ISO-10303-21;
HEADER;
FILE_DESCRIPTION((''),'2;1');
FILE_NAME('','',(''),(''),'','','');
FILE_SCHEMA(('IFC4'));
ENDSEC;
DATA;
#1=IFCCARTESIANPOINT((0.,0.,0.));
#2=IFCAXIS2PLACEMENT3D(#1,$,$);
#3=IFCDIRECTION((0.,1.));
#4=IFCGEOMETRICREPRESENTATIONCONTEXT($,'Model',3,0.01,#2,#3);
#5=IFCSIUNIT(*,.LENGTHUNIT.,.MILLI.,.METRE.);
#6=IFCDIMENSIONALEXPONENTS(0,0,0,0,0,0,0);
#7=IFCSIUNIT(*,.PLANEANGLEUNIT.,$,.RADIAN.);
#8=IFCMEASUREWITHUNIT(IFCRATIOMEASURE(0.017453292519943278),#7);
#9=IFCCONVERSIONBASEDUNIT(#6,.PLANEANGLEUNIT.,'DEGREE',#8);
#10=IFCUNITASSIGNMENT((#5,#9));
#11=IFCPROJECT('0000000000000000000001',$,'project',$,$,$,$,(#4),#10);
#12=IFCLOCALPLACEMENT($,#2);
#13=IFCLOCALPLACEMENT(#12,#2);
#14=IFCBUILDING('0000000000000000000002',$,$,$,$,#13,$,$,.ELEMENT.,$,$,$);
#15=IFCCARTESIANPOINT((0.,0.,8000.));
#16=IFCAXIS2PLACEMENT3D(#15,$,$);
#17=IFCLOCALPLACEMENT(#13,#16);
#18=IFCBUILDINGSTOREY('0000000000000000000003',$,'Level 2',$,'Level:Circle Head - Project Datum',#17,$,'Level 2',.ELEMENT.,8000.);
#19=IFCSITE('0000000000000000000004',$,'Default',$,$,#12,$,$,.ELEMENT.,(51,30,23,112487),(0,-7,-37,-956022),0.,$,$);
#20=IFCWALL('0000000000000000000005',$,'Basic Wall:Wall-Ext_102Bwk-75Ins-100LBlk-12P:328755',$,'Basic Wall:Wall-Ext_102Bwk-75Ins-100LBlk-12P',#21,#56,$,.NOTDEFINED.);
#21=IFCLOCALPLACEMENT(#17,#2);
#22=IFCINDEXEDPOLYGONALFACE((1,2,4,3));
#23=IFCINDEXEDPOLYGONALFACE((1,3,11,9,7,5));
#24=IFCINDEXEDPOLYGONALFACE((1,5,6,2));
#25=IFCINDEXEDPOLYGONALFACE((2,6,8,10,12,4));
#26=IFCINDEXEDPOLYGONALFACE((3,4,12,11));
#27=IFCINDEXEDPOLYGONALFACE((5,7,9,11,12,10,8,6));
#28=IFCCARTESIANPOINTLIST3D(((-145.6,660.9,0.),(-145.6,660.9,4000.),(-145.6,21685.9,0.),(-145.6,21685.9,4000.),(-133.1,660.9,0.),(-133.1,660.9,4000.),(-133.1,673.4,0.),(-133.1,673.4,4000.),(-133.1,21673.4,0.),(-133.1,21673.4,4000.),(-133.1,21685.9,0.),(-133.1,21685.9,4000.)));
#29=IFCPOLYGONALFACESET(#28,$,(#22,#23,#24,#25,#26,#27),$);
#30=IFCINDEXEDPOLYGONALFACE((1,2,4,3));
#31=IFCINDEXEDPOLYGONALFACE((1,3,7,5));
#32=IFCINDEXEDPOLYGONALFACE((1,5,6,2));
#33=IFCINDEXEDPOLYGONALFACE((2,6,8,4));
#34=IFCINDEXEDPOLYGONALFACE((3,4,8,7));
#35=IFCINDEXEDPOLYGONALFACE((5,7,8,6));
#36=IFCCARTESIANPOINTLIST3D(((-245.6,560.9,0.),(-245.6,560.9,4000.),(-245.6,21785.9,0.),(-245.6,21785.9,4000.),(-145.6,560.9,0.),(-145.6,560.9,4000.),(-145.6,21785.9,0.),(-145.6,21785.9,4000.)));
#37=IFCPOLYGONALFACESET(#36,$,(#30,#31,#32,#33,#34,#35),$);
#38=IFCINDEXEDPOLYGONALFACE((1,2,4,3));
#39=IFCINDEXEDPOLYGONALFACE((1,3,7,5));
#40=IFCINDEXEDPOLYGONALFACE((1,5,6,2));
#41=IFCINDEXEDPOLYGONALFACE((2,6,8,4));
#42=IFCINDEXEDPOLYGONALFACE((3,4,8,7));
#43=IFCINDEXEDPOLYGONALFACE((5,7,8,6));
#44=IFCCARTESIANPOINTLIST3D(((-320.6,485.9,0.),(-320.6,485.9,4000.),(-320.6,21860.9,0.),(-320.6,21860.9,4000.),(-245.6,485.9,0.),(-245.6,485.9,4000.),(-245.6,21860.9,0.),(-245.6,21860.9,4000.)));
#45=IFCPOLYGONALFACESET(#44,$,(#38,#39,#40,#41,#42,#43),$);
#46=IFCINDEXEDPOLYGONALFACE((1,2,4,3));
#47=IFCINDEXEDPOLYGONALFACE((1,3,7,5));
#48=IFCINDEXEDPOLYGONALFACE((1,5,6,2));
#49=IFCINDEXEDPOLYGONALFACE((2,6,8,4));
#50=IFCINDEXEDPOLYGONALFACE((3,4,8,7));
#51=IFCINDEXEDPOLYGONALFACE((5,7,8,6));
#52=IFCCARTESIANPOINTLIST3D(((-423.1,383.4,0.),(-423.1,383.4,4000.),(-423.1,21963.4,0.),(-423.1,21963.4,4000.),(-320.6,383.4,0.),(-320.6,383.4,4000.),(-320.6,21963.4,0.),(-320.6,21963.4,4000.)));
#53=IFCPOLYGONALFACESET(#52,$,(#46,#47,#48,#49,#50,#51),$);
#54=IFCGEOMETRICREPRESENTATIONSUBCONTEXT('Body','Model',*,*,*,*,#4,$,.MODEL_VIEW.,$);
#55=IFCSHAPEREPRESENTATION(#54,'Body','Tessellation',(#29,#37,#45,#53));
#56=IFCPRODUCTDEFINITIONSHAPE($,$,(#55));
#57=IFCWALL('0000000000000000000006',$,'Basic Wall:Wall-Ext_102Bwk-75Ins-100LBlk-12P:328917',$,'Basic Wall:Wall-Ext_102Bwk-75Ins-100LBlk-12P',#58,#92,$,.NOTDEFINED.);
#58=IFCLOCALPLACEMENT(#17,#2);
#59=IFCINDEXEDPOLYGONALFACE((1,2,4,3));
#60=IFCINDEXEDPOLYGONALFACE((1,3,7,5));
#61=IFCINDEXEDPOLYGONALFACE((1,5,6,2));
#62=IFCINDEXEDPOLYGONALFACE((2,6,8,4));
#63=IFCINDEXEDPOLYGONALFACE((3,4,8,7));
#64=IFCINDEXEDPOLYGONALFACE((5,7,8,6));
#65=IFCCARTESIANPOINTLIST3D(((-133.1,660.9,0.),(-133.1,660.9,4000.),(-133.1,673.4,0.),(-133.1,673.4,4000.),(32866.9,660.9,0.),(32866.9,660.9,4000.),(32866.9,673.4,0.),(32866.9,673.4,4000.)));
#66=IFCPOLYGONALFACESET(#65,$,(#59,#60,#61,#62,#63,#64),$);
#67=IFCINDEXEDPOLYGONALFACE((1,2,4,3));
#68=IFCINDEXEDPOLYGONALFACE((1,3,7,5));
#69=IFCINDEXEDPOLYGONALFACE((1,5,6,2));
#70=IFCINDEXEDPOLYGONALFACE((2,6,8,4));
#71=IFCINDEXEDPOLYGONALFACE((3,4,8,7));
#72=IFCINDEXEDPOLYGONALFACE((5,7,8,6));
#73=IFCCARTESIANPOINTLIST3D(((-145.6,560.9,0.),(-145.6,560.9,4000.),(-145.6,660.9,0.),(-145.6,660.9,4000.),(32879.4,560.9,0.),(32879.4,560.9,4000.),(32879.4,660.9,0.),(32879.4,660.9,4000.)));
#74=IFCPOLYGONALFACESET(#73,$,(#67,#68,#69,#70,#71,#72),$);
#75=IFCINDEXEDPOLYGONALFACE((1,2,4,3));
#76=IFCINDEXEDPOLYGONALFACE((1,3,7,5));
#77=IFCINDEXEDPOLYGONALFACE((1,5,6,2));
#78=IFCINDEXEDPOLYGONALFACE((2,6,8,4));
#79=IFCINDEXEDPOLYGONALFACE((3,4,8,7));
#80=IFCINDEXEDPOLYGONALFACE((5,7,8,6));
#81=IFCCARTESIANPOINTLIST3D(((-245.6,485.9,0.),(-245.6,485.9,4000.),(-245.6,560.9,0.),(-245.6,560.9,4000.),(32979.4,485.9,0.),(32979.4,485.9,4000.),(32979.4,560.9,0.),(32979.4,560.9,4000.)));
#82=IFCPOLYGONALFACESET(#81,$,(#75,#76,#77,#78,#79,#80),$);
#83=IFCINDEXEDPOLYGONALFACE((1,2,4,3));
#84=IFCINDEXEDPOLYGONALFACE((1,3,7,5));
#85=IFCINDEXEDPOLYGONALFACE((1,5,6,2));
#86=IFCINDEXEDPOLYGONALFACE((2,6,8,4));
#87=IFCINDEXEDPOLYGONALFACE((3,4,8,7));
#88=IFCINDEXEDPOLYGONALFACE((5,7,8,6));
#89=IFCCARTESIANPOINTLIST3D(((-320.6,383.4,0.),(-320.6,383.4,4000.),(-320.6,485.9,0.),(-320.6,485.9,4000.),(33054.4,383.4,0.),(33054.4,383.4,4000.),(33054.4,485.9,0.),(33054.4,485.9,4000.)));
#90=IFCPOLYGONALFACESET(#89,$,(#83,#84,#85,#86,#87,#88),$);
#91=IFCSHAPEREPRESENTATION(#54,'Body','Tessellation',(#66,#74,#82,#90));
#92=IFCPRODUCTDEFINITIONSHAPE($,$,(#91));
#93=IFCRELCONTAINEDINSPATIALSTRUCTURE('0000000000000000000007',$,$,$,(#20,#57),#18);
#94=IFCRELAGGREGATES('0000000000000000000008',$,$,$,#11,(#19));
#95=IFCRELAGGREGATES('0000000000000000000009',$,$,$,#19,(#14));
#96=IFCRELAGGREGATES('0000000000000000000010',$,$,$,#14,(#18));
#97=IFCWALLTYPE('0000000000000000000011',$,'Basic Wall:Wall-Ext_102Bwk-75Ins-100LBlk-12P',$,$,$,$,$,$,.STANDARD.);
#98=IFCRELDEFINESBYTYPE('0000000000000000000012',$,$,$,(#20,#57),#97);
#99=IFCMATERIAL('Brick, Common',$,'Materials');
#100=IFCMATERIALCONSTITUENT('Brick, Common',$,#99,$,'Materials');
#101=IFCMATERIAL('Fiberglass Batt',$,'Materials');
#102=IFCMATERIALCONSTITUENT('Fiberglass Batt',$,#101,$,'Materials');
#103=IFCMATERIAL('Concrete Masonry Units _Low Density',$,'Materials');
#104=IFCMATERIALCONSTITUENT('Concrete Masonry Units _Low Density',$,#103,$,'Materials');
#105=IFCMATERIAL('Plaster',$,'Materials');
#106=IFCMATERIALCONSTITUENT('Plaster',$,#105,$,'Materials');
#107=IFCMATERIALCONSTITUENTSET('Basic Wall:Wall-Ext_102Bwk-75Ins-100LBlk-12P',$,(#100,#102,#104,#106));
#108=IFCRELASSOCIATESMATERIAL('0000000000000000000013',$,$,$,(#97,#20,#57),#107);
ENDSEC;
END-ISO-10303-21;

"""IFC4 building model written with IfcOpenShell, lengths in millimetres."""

from ifc_helpers import new_model, entity, si_unit, converted_unit, direction, frame, origin, place, context, subcontext, project, spatial, indexed_curve, outline, extrude, material, constituent, constituent_set, type_object, element, save


model = new_model("IFC4")

# Units and contexts
model_context = context("Model", 3, precision=0.01, world=origin(), true_north=direction((0.0, 1.0)))
body_context = subcontext(model_context, "Body", "Model", "MODEL_VIEW")
ifc_project = project(units=[si_unit("LENGTHUNIT", "METRE", prefix="MILLI"), converted_unit("PLANEANGLEUNIT", "DEGREE", entity("IfcRatioMeasure", 0.017453292519943278), si_unit("PLANEANGLEUNIT", "RADIAN"), dimensions=[0, 0, 0, 0, 0, 0, 0])], contexts=[model_context])

# Site, building, storey
site_placement = place(None, origin())
site = spatial("IfcSite", under=ifc_project, at=site_placement, Name="Default", CompositionType="ELEMENT", RefLatitude=(51, 30, 23, 112487), RefLongitude=(0, -7, -37, -956022), RefElevation=0.0)
building_placement = place(site_placement, origin())
building = spatial("IfcBuilding", under=site, at=building_placement, CompositionType="ELEMENT")
storey_placement = place(building_placement, frame((0.0, 0.0, 8000.0)))
storey = spatial("IfcBuildingStorey", under=building, at=storey_placement, Name="Level 2", ObjectType="Level:Circle Head - Project Datum", LongName="Level 2", CompositionType="ELEMENT", Elevation=8000.0)

# Walls
ifc_material_1 = material(Name="Brick, Common", Category="Materials")
ifc_constituent_1 = constituent(ifc_material_1, Name="Brick, Common", Category="Materials")
ifc_material_2 = material(Name="Fiberglass Batt", Category="Materials")
ifc_constituent_2 = constituent(ifc_material_2, Name="Fiberglass Batt", Category="Materials")
ifc_material_3 = material(Name="Concrete Masonry Units _Low Density", Category="Materials")
ifc_constituent_3 = constituent(ifc_material_3, Name="Concrete Masonry Units _Low Density", Category="Materials")
ifc_material_4 = material(Name="Plaster", Category="Materials")
ifc_constituent_4 = constituent(ifc_material_4, Name="Plaster", Category="Materials")
ifc_constituent_set_1 = constituent_set(constituents=[ifc_constituent_1, ifc_constituent_2, ifc_constituent_3, ifc_constituent_4], Name="Basic Wall:Wall-Ext_102Bwk-75Ins-100LBlk-12P")
wall_type = type_object("IfcWallType", Name="Basic Wall:Wall-Ext_102Bwk-75Ins-100LBlk-12P", PredefinedType="STANDARD", material=ifc_constituent_set_1)
wall_1_placement = place(storey_placement, frame((-278.1, 383.4, 0.0), z_axis=(0.0, 0.0, 1.0), x_axis=(0.0, 1.0, 0.0)))
element("IfcWall", 1, at=wall_1_placement, inside=storey, type_object=wall_type, material=ifc_constituent_set_1, Name="Basic Wall:Wall-Ext_102Bwk-75Ins-100LBlk-12P:328755", ObjectType="Basic Wall:Wall-Ext_102Bwk-75Ins-100LBlk-12P", PredefinedType="NOTDEFINED", context=body_context, shape_type="SweptSolid", body=[
    extrude(outline(indexed_curve([(-10500.0, -4.2), (10500.0, -4.2), (10512.5, -4.2), (10512.5, 8.3), (-10512.5, 8.3), (-10512.5, -4.2), (-10500.0, -4.2)], self_intersect=False)), frame((10790.0, -140.8, 0.0)), (0.0, 0.0, 1.0), 4000.0),
    extrude(outline(indexed_curve([(-10612.5, -50.0), (10612.5, -50.0), (10612.5, 50.0), (-10612.5, 50.0), (-10612.5, -50.0)], self_intersect=False)), frame((10790.0, -82.5, 0.0)), (0.0, 0.0, 1.0), 4000.0),
    extrude(outline(indexed_curve([(-10687.5, -37.5), (10687.5, -37.5), (10687.5, 37.5), (-10687.5, 37.5), (-10687.5, -37.5)], self_intersect=False)), frame((10790.0, 5.0, 0.0)), (0.0, 0.0, 1.0), 4000.0),
    extrude(outline(indexed_curve([(-51.2, -10790.0), (51.3, -10790.0), (51.2, 10790.0), (-51.3, 10790.0), (-51.2, -10790.0)], self_intersect=False)), frame((10790.0, 93.7, 0.0), z_axis=(0.0, 0.0, 1.0), x_axis=(0.0, -1.0, 0.0)), (0.0, 0.0, 1.0), 4000.0),
])
wall_2_placement = place(storey_placement, frame((32866.9, 528.4, 0.0), z_axis=(0.0, 0.0, 1.0), x_axis=(-1.0, 0.0, 0.0)))
element("IfcWall", 2, at=wall_2_placement, inside=storey, type_object=wall_type, material=ifc_constituent_set_1, Name="Basic Wall:Wall-Ext_102Bwk-75Ins-100LBlk-12P:328917", ObjectType="Basic Wall:Wall-Ext_102Bwk-75Ins-100LBlk-12P", PredefinedType="NOTDEFINED", context=body_context, shape_type="SweptSolid", body=[
    extrude(outline(indexed_curve([(-6.3, -16500.0), (6.2, -16500.0), (6.3, 16500.0), (-6.2, 16500.0), (-6.3, -16500.0)], self_intersect=False)), frame((16500.0, -138.8, 0.0), z_axis=(0.0, 0.0, 1.0), x_axis=(0.0, 1.0, 0.0)), (0.0, 0.0, 1.0), 4000.0),
    extrude(outline(indexed_curve([(-16512.5, -50.0), (16512.5, -50.0), (16512.5, 50.0), (-16512.5, 50.0), (-16512.5, -50.0)], self_intersect=False)), frame((16500.0, -82.5, 0.0)), (0.0, 0.0, 1.0), 4000.0),
    extrude(outline(indexed_curve([(-16612.5, -37.5), (16612.5, -37.5), (16612.5, 37.5), (-16612.5, 37.5), (-16612.5, -37.5)], self_intersect=False)), frame((16500.0, 5.0, 0.0)), (0.0, 0.0, 1.0), 4000.0),
    extrude(outline(indexed_curve([(-51.3, -16687.5), (51.2, -16687.5), (51.3, 16687.5), (-51.2, 16687.5), (-51.3, -16687.5)], self_intersect=False)), frame((16500.0, 93.8, 0.0), z_axis=(0.0, 0.0, 1.0), x_axis=(0.0, -1.0, 0.0)), (0.0, 0.0, 1.0), 4000.0),
])

save(model, "model.ifc")
